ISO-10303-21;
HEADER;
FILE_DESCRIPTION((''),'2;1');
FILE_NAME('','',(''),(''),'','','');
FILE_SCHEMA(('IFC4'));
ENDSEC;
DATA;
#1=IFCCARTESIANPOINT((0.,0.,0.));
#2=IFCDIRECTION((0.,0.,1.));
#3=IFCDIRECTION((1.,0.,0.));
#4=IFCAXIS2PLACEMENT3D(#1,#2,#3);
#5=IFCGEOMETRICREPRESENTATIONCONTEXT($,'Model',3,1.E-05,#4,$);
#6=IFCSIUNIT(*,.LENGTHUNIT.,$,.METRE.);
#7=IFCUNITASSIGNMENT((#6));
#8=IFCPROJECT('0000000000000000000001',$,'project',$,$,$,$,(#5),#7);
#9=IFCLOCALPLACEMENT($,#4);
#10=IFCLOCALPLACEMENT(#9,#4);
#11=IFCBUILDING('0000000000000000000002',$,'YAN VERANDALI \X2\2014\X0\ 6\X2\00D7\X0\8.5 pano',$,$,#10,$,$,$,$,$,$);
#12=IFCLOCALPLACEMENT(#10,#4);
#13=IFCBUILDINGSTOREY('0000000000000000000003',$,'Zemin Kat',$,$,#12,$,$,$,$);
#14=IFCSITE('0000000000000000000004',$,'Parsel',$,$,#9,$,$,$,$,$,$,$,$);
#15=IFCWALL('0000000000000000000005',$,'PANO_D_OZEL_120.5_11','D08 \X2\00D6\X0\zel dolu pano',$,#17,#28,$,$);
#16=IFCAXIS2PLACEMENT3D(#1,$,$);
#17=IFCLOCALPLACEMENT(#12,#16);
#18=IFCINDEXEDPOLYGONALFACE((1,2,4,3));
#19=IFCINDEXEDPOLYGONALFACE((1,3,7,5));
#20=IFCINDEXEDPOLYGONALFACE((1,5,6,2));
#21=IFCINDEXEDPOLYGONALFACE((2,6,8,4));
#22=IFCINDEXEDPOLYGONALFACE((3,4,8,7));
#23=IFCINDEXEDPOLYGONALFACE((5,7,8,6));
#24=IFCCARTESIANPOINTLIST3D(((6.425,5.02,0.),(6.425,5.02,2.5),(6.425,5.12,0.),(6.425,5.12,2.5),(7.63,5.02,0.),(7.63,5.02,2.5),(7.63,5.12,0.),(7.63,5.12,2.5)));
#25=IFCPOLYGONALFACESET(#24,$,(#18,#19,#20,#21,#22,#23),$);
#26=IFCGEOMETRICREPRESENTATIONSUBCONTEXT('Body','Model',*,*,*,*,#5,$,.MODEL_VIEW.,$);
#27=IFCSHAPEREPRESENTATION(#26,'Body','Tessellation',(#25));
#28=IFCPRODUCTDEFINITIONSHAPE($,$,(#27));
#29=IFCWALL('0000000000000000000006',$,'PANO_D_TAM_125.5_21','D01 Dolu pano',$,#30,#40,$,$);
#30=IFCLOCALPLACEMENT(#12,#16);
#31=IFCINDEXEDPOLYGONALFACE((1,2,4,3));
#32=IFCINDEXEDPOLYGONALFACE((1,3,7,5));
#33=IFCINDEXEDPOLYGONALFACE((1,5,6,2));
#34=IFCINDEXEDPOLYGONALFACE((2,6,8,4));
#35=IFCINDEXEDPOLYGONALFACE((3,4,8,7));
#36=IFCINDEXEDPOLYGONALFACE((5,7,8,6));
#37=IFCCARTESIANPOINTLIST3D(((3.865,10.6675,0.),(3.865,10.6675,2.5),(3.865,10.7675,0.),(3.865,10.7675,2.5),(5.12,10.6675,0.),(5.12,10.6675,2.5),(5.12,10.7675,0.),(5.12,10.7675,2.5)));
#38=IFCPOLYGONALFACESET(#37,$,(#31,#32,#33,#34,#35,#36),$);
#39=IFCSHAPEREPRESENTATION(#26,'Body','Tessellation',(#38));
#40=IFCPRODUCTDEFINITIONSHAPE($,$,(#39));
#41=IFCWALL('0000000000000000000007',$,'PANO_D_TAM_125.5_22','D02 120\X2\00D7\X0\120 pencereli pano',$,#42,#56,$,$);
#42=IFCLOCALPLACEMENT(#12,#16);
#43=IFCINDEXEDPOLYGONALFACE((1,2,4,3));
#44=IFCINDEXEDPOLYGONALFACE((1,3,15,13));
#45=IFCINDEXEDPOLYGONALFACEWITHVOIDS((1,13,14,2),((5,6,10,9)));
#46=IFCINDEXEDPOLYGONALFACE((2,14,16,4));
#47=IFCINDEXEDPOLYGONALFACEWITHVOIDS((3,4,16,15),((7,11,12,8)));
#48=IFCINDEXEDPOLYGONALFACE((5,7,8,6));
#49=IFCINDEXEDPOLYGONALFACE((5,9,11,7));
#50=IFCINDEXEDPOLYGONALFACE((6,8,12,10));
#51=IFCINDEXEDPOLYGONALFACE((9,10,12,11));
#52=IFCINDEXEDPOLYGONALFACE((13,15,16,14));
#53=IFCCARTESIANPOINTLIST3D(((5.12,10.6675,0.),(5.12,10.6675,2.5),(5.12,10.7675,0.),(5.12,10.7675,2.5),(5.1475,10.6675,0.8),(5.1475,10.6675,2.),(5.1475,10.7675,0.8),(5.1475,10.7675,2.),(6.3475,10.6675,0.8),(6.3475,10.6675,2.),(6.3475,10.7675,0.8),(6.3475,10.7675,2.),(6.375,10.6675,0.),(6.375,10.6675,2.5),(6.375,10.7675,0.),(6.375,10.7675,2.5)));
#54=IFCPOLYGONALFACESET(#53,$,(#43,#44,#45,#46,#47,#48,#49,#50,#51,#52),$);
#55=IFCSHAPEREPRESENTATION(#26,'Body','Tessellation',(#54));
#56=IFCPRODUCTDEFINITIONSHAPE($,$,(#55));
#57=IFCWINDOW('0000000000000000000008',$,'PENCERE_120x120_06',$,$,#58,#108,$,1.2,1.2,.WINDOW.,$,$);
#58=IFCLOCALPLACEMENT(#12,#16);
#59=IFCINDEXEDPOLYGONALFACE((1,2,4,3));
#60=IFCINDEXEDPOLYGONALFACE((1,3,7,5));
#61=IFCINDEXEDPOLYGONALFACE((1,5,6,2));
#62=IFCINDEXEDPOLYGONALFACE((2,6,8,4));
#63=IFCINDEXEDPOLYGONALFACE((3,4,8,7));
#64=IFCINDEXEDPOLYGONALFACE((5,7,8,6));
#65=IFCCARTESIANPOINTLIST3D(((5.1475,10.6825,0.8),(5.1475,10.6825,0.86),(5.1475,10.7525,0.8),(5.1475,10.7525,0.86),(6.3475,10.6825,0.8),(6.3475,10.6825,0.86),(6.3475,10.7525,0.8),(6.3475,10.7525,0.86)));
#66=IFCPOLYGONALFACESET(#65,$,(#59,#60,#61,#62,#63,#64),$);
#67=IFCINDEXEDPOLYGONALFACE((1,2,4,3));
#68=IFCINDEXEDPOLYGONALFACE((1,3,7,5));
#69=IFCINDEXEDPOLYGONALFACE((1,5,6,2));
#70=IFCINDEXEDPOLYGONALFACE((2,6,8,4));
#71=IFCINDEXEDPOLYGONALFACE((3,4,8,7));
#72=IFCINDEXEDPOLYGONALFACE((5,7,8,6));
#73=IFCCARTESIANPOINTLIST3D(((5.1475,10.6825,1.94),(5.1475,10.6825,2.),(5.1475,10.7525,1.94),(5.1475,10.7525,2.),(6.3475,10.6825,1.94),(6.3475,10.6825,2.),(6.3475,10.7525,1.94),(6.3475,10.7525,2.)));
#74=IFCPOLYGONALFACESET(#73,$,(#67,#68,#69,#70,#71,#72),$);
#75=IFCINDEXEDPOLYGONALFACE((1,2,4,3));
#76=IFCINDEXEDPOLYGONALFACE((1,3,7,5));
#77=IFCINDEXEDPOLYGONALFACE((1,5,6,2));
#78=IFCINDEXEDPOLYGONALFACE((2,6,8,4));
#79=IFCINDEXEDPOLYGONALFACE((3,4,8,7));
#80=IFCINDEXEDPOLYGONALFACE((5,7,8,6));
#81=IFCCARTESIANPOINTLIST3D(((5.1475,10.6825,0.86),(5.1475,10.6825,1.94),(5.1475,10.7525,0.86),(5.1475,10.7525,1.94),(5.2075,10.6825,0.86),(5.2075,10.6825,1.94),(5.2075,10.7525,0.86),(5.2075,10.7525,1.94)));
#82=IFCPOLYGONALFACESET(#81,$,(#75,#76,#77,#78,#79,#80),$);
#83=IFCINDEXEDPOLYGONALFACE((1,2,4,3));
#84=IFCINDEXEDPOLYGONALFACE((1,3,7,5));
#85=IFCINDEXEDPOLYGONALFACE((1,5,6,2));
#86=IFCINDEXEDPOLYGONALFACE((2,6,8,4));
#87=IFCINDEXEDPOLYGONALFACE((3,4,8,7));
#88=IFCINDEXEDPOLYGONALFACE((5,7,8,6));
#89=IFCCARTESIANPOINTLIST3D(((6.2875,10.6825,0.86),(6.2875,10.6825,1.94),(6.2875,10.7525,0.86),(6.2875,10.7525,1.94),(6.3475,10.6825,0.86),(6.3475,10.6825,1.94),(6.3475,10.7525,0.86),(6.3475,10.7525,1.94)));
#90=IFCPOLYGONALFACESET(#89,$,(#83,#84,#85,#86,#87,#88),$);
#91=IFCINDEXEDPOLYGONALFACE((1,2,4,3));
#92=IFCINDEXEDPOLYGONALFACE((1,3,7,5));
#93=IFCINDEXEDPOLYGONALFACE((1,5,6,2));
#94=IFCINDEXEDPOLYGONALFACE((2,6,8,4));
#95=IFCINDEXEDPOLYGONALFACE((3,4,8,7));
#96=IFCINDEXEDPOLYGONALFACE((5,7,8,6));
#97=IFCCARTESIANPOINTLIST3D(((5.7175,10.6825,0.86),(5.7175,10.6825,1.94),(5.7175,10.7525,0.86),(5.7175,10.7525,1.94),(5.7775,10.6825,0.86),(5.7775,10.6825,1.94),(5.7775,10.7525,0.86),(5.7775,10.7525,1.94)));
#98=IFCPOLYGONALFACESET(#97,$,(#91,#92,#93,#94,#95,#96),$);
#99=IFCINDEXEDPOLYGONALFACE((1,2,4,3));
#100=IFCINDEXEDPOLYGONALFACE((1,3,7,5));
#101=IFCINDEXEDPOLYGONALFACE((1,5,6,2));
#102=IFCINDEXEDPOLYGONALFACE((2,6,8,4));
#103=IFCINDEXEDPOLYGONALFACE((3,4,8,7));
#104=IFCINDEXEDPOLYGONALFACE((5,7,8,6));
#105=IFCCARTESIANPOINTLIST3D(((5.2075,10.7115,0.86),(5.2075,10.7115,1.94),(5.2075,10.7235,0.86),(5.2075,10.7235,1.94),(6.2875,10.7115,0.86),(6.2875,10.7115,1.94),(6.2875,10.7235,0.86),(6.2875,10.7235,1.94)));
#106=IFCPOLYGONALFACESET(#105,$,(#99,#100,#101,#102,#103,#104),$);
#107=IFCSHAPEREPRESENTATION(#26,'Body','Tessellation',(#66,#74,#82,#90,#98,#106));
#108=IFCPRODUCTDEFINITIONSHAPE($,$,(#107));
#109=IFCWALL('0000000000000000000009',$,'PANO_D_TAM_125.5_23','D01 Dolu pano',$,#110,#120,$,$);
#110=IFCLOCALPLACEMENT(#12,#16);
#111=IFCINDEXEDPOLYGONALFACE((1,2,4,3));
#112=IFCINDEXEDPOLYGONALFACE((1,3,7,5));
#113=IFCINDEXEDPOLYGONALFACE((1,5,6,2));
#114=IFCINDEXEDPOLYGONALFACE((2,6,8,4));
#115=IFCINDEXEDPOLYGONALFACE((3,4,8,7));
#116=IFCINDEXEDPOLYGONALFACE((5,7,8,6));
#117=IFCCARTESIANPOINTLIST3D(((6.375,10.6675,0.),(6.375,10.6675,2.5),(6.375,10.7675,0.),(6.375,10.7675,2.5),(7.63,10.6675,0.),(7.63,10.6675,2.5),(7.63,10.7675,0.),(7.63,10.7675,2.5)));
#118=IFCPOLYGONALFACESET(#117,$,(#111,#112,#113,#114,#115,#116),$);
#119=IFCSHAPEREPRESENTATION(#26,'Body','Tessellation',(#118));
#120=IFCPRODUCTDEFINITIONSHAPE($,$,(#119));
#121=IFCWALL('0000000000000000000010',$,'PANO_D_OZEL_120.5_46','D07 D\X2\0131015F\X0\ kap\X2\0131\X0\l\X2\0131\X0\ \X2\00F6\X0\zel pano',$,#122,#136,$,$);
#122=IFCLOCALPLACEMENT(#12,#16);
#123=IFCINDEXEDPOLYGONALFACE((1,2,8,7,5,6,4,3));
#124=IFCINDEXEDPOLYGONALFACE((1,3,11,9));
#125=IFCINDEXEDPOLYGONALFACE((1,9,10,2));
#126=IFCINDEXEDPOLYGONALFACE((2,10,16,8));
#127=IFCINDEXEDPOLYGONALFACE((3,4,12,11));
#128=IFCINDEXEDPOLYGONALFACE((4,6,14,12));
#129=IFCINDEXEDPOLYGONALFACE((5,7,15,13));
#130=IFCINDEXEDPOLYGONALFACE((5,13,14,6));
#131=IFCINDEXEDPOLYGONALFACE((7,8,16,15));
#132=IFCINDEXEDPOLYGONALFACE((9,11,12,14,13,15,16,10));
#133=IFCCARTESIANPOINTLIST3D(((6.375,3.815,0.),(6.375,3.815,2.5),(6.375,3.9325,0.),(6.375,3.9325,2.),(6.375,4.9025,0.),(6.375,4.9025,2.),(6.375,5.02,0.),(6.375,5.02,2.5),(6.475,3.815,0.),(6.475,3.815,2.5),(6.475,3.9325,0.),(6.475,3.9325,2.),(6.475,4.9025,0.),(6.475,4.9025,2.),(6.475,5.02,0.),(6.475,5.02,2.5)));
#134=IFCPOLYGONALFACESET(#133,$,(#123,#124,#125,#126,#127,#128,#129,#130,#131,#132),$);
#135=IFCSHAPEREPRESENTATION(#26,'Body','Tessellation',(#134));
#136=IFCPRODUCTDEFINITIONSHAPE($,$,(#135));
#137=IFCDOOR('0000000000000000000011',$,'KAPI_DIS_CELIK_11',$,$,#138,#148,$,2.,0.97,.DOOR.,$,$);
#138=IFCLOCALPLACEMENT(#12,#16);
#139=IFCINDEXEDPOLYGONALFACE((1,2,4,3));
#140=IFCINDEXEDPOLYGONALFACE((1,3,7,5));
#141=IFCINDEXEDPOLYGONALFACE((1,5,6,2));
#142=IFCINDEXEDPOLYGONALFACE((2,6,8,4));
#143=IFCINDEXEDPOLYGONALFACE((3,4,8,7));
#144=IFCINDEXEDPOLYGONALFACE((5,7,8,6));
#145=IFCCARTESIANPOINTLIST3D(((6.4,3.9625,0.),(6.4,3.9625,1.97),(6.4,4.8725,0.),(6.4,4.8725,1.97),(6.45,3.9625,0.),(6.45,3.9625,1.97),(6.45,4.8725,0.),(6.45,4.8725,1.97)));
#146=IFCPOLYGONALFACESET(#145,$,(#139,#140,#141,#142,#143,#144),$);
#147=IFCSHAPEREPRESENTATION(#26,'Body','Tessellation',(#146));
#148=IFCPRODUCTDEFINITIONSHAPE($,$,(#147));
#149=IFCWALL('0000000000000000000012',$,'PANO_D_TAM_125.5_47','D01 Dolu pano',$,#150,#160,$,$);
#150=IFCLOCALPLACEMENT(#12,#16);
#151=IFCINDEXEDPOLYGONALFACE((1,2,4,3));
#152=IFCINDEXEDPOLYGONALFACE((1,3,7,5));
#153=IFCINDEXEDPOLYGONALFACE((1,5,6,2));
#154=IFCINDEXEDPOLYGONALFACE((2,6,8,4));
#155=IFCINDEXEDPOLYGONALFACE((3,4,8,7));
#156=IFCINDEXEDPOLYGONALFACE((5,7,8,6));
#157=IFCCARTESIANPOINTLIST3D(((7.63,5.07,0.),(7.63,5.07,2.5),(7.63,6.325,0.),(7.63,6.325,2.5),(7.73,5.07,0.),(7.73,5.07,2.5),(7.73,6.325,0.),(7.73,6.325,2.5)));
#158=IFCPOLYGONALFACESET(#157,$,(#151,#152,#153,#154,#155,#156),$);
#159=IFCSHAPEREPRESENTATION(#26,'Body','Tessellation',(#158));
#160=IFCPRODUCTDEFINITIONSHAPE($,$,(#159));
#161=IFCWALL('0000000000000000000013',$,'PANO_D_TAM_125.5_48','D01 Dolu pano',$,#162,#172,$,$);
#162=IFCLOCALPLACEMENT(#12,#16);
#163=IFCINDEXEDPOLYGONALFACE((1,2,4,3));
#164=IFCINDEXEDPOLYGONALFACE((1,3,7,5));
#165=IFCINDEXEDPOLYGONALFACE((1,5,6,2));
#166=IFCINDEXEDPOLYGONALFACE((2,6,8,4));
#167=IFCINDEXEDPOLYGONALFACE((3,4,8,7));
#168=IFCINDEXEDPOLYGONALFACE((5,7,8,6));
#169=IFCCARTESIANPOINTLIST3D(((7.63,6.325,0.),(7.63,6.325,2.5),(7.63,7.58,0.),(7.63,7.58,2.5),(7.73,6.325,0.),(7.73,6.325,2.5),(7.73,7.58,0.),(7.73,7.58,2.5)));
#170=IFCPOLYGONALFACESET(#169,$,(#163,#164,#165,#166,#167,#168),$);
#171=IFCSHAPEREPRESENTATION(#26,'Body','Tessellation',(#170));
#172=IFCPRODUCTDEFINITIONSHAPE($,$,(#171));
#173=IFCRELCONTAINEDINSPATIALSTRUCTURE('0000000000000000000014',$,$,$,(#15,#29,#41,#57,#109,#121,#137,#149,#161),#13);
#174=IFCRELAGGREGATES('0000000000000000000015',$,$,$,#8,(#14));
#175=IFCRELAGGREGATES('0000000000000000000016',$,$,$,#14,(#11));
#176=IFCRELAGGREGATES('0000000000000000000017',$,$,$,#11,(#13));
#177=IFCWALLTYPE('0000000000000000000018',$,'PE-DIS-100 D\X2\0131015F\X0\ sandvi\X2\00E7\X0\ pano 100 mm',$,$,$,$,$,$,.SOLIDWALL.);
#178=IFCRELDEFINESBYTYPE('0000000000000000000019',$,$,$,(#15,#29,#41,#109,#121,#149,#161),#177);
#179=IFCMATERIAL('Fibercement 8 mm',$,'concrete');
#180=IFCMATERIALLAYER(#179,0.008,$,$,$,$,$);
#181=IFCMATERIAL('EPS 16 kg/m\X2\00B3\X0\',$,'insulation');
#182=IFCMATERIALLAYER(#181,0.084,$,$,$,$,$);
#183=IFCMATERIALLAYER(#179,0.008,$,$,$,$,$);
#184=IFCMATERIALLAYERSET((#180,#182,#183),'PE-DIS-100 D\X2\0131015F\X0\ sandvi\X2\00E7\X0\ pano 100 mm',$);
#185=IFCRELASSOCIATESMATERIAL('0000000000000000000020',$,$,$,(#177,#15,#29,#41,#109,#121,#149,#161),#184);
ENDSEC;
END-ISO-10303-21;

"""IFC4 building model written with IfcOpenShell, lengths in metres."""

from ifc_helpers import new_model, si_unit, frame, origin_with_axes, place, context, subcontext, project, spatial, line, indexed_curve, outline, extrude, material, layer, layer_set, layer_usage, type_object, element, fill, save


model = new_model("IFC4")

# Units and contexts
model_context = context("Model", 3, precision=1e-05, world=origin_with_axes())
body_context = subcontext(model_context, "Body", "Model", "MODEL_VIEW")
ifc_project = project(units=[si_unit("LENGTHUNIT", "METRE")], contexts=[model_context])

# Site, building, storey
site_placement = place(None, origin_with_axes())
site = spatial("IfcSite", under=ifc_project, at=site_placement, Name="Parsel")
building_placement = place(site_placement, origin_with_axes())
building = spatial("IfcBuilding", under=site, at=building_placement, Name="YAN VERANDALI — 6×8.5 pano")
storey_placement = place(building_placement, origin_with_axes())
storey = spatial("IfcBuildingStorey", under=building, at=storey_placement, Name="Zemin Kat")

# Walls
ifc_material_1 = material(Name="Fibercement 8 mm", Category="concrete")
ifc_layer_1 = layer(ifc_material_1, 0.008)
ifc_material_2 = material(Name="EPS 16 kg/m³", Category="insulation")
ifc_layer_2 = layer(ifc_material_2, 0.084)
ifc_layer_3 = layer(ifc_material_1, 0.008)
ifc_layer_set_1 = layer_set([ifc_layer_1, ifc_layer_2, ifc_layer_3], Name="PE-DIS-100 Dış sandviç pano 100 mm")
ifc_layer_usage_1 = layer_usage(ifc_layer_set_1, "AXIS2", "POSITIVE", 0.0)
wall_type_1 = type_object("IfcWallType", Name="PE-DIS-100 Dış sandviç pano 100 mm", PredefinedType="SOLIDWALL", material=ifc_layer_set_1)
wall_1_placement = place(storey_placement, frame((6.425, 5.02, 0.0), z_axis=(0.0, 0.0, 1.0), x_axis=(1.0, 0.0, 0.0)))
element("IfcWall", 1, at=wall_1_placement, inside=storey, type_object=wall_type_1, material=ifc_layer_usage_1, Name="PANO_D_OZEL_120.5_11", Description="D08 Özel dolu pano", context=body_context, shape_type="SweptSolid", body=[
    extrude(outline(indexed_curve([(0.0, 0.0), (1.205, 0.0), (1.205, 0.1), (0.0, 0.1)], segments=[line(1, 2, 3, 4, 1)])), origin_with_axes(), (0.0, 0.0, 1.0), 2.5),
])
ifc_layer_usage_2 = layer_usage(ifc_layer_set_1, "AXIS2", "POSITIVE", 0.0)
wall_2_placement = place(storey_placement, frame((3.865, 10.6675, 0.0), z_axis=(0.0, 0.0, 1.0), x_axis=(1.0, 0.0, 0.0)))
element("IfcWall", 2, at=wall_2_placement, inside=storey, type_object=wall_type_1, material=ifc_layer_usage_2, Name="PANO_D_TAM_125.5_21", Description="D01 Dolu pano", context=body_context, shape_type="SweptSolid", body=[
    extrude(outline(indexed_curve([(0.0, 0.0), (1.255, 0.0), (1.255, 0.1), (0.0, 0.1)], segments=[line(1, 2, 3, 4, 1)])), origin_with_axes(), (0.0, 0.0, 1.0), 2.5),
])

# Wall, opening, window
ifc_layer_usage_3 = layer_usage(ifc_layer_set_1, "AXIS2", "POSITIVE", 0.0)
wall_3_placement = place(storey_placement, frame((5.12, 10.6675, 0.0), z_axis=(0.0, 0.0, 1.0), x_axis=(1.0, 0.0, 0.0)))
wall_3 = element("IfcWall", 3, at=wall_3_placement, inside=storey, type_object=wall_type_1, material=ifc_layer_usage_3, Name="PANO_D_TAM_125.5_22", Description="D02 120×120 pencereli pano", context=body_context, shape_type="SweptSolid", body=[
    extrude(outline(indexed_curve([(0.0, 0.0), (1.255, 0.0), (1.255, 0.1), (0.0, 0.1)], segments=[line(1, 2, 3, 4, 1)])), origin_with_axes(), (0.0, 0.0, 1.0), 2.5),
])
opening_1_placement = place(wall_3_placement, origin_with_axes())
opening_1 = element("IfcOpeningElement", 4, at=opening_1_placement, cuts=wall_3, PredefinedType="OPENING", context=body_context, shape_type="SweptSolid", body=[
    extrude(outline(indexed_curve([(0.0, 0.0), (1.2, 0.0), (1.2, 0.14), (0.0, 0.14)], segments=[line(1, 2, 3, 4, 1)])), frame((0.0275, -0.02, 0.8), z_axis=(0.0, 0.0, 1.0), x_axis=(1.0, 0.0, 0.0)), (0.0, 0.0, 1.0), 1.2),
])
window_1_placement = place(storey_placement, frame((5.12, 10.6675, 0.0), z_axis=(0.0, 0.0, 1.0), x_axis=(1.0, 0.0, 0.0)))
window_1 = element("IfcWindow", 5, at=window_1_placement, inside=storey, Name="PENCERE_120x120_06", OverallHeight=1.2, OverallWidth=1.2, PredefinedType="WINDOW", context=body_context, shape_type="SweptSolid", body=[
    extrude(outline(indexed_curve([(0.0, 0.0), (1.2, 0.0), (1.2, 0.07), (0.0, 0.07)], segments=[line(1, 2, 3, 4, 1)])), frame((0.0275, 0.015, 0.8), z_axis=(0.0, 0.0, 1.0), x_axis=(1.0, 0.0, 0.0)), (0.0, 0.0, 1.0), 0.06),
    extrude(outline(indexed_curve([(0.0, 0.0), (1.2, 0.0), (1.2, 0.07), (0.0, 0.07)], segments=[line(1, 2, 3, 4, 1)])), frame((0.0275, 0.015, 1.94), z_axis=(0.0, 0.0, 1.0), x_axis=(1.0, 0.0, 0.0)), (0.0, 0.0, 1.0), 0.06),
    extrude(outline(indexed_curve([(0.0, 0.0), (0.06, 0.0), (0.06, 0.07), (0.0, 0.07)], segments=[line(1, 2, 3, 4, 1)])), frame((0.0275, 0.015, 0.86), z_axis=(0.0, 0.0, 1.0), x_axis=(1.0, 0.0, 0.0)), (0.0, 0.0, 1.0), 1.08),
    extrude(outline(indexed_curve([(0.0, 0.0), (0.06, 0.0), (0.06, 0.07), (0.0, 0.07)], segments=[line(1, 2, 3, 4, 1)])), frame((1.1675, 0.015, 0.86), z_axis=(0.0, 0.0, 1.0), x_axis=(1.0, 0.0, 0.0)), (0.0, 0.0, 1.0), 1.08),
    extrude(outline(indexed_curve([(0.0, 0.0), (0.06, 0.0), (0.06, 0.07), (0.0, 0.07)], segments=[line(1, 2, 3, 4, 1)])), frame((0.5975, 0.015, 0.86), z_axis=(0.0, 0.0, 1.0), x_axis=(1.0, 0.0, 0.0)), (0.0, 0.0, 1.0), 1.08),
    extrude(outline(indexed_curve([(0.0, 0.0), (1.08, 0.0), (1.08, 0.012), (0.0, 0.012)], segments=[line(1, 2, 3, 4, 1)])), frame((0.0875, 0.044, 0.86), z_axis=(0.0, 0.0, 1.0), x_axis=(1.0, 0.0, 0.0)), (0.0, 0.0, 1.0), 1.08),
])
fill(opening_1, window_1)

# Wall
ifc_layer_usage_4 = layer_usage(ifc_layer_set_1, "AXIS2", "POSITIVE", 0.0)
wall_4_placement = place(storey_placement, frame((6.375, 10.6675, 0.0), z_axis=(0.0, 0.0, 1.0), x_axis=(1.0, 0.0, 0.0)))
element("IfcWall", 6, at=wall_4_placement, inside=storey, type_object=wall_type_1, material=ifc_layer_usage_4, Name="PANO_D_TAM_125.5_23", Description="D01 Dolu pano", context=body_context, shape_type="SweptSolid", body=[
    extrude(outline(indexed_curve([(0.0, 0.0), (1.255, 0.0), (1.255, 0.1), (0.0, 0.1)], segments=[line(1, 2, 3, 4, 1)])), origin_with_axes(), (0.0, 0.0, 1.0), 2.5),
])

# Wall, opening, door
ifc_layer_usage_5 = layer_usage(ifc_layer_set_1, "AXIS2", "POSITIVE", 0.0)
wall_5_placement = place(storey_placement, frame((6.475, 3.815, 0.0), z_axis=(0.0, 0.0, 1.0), x_axis=(0.0, 1.0, 0.0)))
wall_5 = element("IfcWall", 7, at=wall_5_placement, inside=storey, type_object=wall_type_1, material=ifc_layer_usage_5, Name="PANO_D_OZEL_120.5_46", Description="D07 Dış kapılı özel pano", context=body_context, shape_type="SweptSolid", body=[
    extrude(outline(indexed_curve([(0.0, 0.0), (1.205, 0.0), (1.205, 0.1), (0.0, 0.1)], segments=[line(1, 2, 3, 4, 1)])), origin_with_axes(), (0.0, 0.0, 1.0), 2.5),
])
opening_2_placement = place(wall_5_placement, origin_with_axes())
opening_2 = element("IfcOpeningElement", 8, at=opening_2_placement, cuts=wall_5, PredefinedType="OPENING", context=body_context, shape_type="SweptSolid", body=[
    extrude(outline(indexed_curve([(0.0, 0.0), (0.97, 0.0), (0.97, 0.14), (0.0, 0.14)], segments=[line(1, 2, 3, 4, 1)])), frame((0.1175, -0.02, 0.0), z_axis=(0.0, 0.0, 1.0), x_axis=(1.0, 0.0, 0.0)), (0.0, 0.0, 1.0), 2.0),
])
door_placement = place(storey_placement, frame((6.475, 3.815, 0.0), z_axis=(0.0, 0.0, 1.0), x_axis=(0.0, 1.0, 0.0)))
door = element("IfcDoor", 9, at=door_placement, inside=storey, Name="KAPI_DIS_CELIK_11", OverallHeight=2.0, OverallWidth=0.97, PredefinedType="DOOR", context=body_context, shape_type="SweptSolid", body=[
    extrude(outline(indexed_curve([(0.0, 0.0), (0.91, 0.0), (0.91, 0.05), (0.0, 0.05)], segments=[line(1, 2, 3, 4, 1)])), frame((0.1475, 0.025, 0.0), z_axis=(0.0, 0.0, 1.0), x_axis=(1.0, 0.0, 0.0)), (0.0, 0.0, 1.0), 1.97),
])
fill(opening_2, door)

# Walls
ifc_layer_usage_6 = layer_usage(ifc_layer_set_1, "AXIS2", "POSITIVE", 0.0)
wall_6_placement = place(storey_placement, frame((7.73, 5.07, 0.0), z_axis=(0.0, 0.0, 1.0), x_axis=(0.0, 1.0, 0.0)))
element("IfcWall", 10, at=wall_6_placement, inside=storey, type_object=wall_type_1, material=ifc_layer_usage_6, Name="PANO_D_TAM_125.5_47", Description="D01 Dolu pano", context=body_context, shape_type="SweptSolid", body=[
    extrude(outline(indexed_curve([(0.0, 0.0), (1.255, 0.0), (1.255, 0.1), (0.0, 0.1)], segments=[line(1, 2, 3, 4, 1)])), origin_with_axes(), (0.0, 0.0, 1.0), 2.5),
])
ifc_layer_usage_7 = layer_usage(ifc_layer_set_1, "AXIS2", "POSITIVE", 0.0)
wall_7_placement = place(storey_placement, frame((7.73, 6.325, 0.0), z_axis=(0.0, 0.0, 1.0), x_axis=(0.0, 1.0, 0.0)))
element("IfcWall", 11, at=wall_7_placement, inside=storey, type_object=wall_type_1, material=ifc_layer_usage_7, Name="PANO_D_TAM_125.5_48", Description="D01 Dolu pano", context=body_context, shape_type="SweptSolid", body=[
    extrude(outline(indexed_curve([(0.0, 0.0), (1.255, 0.0), (1.255, 0.1), (0.0, 0.1)], segments=[line(1, 2, 3, 4, 1)])), origin_with_axes(), (0.0, 0.0, 1.0), 2.5),
])

save(model, "model.ifc")
